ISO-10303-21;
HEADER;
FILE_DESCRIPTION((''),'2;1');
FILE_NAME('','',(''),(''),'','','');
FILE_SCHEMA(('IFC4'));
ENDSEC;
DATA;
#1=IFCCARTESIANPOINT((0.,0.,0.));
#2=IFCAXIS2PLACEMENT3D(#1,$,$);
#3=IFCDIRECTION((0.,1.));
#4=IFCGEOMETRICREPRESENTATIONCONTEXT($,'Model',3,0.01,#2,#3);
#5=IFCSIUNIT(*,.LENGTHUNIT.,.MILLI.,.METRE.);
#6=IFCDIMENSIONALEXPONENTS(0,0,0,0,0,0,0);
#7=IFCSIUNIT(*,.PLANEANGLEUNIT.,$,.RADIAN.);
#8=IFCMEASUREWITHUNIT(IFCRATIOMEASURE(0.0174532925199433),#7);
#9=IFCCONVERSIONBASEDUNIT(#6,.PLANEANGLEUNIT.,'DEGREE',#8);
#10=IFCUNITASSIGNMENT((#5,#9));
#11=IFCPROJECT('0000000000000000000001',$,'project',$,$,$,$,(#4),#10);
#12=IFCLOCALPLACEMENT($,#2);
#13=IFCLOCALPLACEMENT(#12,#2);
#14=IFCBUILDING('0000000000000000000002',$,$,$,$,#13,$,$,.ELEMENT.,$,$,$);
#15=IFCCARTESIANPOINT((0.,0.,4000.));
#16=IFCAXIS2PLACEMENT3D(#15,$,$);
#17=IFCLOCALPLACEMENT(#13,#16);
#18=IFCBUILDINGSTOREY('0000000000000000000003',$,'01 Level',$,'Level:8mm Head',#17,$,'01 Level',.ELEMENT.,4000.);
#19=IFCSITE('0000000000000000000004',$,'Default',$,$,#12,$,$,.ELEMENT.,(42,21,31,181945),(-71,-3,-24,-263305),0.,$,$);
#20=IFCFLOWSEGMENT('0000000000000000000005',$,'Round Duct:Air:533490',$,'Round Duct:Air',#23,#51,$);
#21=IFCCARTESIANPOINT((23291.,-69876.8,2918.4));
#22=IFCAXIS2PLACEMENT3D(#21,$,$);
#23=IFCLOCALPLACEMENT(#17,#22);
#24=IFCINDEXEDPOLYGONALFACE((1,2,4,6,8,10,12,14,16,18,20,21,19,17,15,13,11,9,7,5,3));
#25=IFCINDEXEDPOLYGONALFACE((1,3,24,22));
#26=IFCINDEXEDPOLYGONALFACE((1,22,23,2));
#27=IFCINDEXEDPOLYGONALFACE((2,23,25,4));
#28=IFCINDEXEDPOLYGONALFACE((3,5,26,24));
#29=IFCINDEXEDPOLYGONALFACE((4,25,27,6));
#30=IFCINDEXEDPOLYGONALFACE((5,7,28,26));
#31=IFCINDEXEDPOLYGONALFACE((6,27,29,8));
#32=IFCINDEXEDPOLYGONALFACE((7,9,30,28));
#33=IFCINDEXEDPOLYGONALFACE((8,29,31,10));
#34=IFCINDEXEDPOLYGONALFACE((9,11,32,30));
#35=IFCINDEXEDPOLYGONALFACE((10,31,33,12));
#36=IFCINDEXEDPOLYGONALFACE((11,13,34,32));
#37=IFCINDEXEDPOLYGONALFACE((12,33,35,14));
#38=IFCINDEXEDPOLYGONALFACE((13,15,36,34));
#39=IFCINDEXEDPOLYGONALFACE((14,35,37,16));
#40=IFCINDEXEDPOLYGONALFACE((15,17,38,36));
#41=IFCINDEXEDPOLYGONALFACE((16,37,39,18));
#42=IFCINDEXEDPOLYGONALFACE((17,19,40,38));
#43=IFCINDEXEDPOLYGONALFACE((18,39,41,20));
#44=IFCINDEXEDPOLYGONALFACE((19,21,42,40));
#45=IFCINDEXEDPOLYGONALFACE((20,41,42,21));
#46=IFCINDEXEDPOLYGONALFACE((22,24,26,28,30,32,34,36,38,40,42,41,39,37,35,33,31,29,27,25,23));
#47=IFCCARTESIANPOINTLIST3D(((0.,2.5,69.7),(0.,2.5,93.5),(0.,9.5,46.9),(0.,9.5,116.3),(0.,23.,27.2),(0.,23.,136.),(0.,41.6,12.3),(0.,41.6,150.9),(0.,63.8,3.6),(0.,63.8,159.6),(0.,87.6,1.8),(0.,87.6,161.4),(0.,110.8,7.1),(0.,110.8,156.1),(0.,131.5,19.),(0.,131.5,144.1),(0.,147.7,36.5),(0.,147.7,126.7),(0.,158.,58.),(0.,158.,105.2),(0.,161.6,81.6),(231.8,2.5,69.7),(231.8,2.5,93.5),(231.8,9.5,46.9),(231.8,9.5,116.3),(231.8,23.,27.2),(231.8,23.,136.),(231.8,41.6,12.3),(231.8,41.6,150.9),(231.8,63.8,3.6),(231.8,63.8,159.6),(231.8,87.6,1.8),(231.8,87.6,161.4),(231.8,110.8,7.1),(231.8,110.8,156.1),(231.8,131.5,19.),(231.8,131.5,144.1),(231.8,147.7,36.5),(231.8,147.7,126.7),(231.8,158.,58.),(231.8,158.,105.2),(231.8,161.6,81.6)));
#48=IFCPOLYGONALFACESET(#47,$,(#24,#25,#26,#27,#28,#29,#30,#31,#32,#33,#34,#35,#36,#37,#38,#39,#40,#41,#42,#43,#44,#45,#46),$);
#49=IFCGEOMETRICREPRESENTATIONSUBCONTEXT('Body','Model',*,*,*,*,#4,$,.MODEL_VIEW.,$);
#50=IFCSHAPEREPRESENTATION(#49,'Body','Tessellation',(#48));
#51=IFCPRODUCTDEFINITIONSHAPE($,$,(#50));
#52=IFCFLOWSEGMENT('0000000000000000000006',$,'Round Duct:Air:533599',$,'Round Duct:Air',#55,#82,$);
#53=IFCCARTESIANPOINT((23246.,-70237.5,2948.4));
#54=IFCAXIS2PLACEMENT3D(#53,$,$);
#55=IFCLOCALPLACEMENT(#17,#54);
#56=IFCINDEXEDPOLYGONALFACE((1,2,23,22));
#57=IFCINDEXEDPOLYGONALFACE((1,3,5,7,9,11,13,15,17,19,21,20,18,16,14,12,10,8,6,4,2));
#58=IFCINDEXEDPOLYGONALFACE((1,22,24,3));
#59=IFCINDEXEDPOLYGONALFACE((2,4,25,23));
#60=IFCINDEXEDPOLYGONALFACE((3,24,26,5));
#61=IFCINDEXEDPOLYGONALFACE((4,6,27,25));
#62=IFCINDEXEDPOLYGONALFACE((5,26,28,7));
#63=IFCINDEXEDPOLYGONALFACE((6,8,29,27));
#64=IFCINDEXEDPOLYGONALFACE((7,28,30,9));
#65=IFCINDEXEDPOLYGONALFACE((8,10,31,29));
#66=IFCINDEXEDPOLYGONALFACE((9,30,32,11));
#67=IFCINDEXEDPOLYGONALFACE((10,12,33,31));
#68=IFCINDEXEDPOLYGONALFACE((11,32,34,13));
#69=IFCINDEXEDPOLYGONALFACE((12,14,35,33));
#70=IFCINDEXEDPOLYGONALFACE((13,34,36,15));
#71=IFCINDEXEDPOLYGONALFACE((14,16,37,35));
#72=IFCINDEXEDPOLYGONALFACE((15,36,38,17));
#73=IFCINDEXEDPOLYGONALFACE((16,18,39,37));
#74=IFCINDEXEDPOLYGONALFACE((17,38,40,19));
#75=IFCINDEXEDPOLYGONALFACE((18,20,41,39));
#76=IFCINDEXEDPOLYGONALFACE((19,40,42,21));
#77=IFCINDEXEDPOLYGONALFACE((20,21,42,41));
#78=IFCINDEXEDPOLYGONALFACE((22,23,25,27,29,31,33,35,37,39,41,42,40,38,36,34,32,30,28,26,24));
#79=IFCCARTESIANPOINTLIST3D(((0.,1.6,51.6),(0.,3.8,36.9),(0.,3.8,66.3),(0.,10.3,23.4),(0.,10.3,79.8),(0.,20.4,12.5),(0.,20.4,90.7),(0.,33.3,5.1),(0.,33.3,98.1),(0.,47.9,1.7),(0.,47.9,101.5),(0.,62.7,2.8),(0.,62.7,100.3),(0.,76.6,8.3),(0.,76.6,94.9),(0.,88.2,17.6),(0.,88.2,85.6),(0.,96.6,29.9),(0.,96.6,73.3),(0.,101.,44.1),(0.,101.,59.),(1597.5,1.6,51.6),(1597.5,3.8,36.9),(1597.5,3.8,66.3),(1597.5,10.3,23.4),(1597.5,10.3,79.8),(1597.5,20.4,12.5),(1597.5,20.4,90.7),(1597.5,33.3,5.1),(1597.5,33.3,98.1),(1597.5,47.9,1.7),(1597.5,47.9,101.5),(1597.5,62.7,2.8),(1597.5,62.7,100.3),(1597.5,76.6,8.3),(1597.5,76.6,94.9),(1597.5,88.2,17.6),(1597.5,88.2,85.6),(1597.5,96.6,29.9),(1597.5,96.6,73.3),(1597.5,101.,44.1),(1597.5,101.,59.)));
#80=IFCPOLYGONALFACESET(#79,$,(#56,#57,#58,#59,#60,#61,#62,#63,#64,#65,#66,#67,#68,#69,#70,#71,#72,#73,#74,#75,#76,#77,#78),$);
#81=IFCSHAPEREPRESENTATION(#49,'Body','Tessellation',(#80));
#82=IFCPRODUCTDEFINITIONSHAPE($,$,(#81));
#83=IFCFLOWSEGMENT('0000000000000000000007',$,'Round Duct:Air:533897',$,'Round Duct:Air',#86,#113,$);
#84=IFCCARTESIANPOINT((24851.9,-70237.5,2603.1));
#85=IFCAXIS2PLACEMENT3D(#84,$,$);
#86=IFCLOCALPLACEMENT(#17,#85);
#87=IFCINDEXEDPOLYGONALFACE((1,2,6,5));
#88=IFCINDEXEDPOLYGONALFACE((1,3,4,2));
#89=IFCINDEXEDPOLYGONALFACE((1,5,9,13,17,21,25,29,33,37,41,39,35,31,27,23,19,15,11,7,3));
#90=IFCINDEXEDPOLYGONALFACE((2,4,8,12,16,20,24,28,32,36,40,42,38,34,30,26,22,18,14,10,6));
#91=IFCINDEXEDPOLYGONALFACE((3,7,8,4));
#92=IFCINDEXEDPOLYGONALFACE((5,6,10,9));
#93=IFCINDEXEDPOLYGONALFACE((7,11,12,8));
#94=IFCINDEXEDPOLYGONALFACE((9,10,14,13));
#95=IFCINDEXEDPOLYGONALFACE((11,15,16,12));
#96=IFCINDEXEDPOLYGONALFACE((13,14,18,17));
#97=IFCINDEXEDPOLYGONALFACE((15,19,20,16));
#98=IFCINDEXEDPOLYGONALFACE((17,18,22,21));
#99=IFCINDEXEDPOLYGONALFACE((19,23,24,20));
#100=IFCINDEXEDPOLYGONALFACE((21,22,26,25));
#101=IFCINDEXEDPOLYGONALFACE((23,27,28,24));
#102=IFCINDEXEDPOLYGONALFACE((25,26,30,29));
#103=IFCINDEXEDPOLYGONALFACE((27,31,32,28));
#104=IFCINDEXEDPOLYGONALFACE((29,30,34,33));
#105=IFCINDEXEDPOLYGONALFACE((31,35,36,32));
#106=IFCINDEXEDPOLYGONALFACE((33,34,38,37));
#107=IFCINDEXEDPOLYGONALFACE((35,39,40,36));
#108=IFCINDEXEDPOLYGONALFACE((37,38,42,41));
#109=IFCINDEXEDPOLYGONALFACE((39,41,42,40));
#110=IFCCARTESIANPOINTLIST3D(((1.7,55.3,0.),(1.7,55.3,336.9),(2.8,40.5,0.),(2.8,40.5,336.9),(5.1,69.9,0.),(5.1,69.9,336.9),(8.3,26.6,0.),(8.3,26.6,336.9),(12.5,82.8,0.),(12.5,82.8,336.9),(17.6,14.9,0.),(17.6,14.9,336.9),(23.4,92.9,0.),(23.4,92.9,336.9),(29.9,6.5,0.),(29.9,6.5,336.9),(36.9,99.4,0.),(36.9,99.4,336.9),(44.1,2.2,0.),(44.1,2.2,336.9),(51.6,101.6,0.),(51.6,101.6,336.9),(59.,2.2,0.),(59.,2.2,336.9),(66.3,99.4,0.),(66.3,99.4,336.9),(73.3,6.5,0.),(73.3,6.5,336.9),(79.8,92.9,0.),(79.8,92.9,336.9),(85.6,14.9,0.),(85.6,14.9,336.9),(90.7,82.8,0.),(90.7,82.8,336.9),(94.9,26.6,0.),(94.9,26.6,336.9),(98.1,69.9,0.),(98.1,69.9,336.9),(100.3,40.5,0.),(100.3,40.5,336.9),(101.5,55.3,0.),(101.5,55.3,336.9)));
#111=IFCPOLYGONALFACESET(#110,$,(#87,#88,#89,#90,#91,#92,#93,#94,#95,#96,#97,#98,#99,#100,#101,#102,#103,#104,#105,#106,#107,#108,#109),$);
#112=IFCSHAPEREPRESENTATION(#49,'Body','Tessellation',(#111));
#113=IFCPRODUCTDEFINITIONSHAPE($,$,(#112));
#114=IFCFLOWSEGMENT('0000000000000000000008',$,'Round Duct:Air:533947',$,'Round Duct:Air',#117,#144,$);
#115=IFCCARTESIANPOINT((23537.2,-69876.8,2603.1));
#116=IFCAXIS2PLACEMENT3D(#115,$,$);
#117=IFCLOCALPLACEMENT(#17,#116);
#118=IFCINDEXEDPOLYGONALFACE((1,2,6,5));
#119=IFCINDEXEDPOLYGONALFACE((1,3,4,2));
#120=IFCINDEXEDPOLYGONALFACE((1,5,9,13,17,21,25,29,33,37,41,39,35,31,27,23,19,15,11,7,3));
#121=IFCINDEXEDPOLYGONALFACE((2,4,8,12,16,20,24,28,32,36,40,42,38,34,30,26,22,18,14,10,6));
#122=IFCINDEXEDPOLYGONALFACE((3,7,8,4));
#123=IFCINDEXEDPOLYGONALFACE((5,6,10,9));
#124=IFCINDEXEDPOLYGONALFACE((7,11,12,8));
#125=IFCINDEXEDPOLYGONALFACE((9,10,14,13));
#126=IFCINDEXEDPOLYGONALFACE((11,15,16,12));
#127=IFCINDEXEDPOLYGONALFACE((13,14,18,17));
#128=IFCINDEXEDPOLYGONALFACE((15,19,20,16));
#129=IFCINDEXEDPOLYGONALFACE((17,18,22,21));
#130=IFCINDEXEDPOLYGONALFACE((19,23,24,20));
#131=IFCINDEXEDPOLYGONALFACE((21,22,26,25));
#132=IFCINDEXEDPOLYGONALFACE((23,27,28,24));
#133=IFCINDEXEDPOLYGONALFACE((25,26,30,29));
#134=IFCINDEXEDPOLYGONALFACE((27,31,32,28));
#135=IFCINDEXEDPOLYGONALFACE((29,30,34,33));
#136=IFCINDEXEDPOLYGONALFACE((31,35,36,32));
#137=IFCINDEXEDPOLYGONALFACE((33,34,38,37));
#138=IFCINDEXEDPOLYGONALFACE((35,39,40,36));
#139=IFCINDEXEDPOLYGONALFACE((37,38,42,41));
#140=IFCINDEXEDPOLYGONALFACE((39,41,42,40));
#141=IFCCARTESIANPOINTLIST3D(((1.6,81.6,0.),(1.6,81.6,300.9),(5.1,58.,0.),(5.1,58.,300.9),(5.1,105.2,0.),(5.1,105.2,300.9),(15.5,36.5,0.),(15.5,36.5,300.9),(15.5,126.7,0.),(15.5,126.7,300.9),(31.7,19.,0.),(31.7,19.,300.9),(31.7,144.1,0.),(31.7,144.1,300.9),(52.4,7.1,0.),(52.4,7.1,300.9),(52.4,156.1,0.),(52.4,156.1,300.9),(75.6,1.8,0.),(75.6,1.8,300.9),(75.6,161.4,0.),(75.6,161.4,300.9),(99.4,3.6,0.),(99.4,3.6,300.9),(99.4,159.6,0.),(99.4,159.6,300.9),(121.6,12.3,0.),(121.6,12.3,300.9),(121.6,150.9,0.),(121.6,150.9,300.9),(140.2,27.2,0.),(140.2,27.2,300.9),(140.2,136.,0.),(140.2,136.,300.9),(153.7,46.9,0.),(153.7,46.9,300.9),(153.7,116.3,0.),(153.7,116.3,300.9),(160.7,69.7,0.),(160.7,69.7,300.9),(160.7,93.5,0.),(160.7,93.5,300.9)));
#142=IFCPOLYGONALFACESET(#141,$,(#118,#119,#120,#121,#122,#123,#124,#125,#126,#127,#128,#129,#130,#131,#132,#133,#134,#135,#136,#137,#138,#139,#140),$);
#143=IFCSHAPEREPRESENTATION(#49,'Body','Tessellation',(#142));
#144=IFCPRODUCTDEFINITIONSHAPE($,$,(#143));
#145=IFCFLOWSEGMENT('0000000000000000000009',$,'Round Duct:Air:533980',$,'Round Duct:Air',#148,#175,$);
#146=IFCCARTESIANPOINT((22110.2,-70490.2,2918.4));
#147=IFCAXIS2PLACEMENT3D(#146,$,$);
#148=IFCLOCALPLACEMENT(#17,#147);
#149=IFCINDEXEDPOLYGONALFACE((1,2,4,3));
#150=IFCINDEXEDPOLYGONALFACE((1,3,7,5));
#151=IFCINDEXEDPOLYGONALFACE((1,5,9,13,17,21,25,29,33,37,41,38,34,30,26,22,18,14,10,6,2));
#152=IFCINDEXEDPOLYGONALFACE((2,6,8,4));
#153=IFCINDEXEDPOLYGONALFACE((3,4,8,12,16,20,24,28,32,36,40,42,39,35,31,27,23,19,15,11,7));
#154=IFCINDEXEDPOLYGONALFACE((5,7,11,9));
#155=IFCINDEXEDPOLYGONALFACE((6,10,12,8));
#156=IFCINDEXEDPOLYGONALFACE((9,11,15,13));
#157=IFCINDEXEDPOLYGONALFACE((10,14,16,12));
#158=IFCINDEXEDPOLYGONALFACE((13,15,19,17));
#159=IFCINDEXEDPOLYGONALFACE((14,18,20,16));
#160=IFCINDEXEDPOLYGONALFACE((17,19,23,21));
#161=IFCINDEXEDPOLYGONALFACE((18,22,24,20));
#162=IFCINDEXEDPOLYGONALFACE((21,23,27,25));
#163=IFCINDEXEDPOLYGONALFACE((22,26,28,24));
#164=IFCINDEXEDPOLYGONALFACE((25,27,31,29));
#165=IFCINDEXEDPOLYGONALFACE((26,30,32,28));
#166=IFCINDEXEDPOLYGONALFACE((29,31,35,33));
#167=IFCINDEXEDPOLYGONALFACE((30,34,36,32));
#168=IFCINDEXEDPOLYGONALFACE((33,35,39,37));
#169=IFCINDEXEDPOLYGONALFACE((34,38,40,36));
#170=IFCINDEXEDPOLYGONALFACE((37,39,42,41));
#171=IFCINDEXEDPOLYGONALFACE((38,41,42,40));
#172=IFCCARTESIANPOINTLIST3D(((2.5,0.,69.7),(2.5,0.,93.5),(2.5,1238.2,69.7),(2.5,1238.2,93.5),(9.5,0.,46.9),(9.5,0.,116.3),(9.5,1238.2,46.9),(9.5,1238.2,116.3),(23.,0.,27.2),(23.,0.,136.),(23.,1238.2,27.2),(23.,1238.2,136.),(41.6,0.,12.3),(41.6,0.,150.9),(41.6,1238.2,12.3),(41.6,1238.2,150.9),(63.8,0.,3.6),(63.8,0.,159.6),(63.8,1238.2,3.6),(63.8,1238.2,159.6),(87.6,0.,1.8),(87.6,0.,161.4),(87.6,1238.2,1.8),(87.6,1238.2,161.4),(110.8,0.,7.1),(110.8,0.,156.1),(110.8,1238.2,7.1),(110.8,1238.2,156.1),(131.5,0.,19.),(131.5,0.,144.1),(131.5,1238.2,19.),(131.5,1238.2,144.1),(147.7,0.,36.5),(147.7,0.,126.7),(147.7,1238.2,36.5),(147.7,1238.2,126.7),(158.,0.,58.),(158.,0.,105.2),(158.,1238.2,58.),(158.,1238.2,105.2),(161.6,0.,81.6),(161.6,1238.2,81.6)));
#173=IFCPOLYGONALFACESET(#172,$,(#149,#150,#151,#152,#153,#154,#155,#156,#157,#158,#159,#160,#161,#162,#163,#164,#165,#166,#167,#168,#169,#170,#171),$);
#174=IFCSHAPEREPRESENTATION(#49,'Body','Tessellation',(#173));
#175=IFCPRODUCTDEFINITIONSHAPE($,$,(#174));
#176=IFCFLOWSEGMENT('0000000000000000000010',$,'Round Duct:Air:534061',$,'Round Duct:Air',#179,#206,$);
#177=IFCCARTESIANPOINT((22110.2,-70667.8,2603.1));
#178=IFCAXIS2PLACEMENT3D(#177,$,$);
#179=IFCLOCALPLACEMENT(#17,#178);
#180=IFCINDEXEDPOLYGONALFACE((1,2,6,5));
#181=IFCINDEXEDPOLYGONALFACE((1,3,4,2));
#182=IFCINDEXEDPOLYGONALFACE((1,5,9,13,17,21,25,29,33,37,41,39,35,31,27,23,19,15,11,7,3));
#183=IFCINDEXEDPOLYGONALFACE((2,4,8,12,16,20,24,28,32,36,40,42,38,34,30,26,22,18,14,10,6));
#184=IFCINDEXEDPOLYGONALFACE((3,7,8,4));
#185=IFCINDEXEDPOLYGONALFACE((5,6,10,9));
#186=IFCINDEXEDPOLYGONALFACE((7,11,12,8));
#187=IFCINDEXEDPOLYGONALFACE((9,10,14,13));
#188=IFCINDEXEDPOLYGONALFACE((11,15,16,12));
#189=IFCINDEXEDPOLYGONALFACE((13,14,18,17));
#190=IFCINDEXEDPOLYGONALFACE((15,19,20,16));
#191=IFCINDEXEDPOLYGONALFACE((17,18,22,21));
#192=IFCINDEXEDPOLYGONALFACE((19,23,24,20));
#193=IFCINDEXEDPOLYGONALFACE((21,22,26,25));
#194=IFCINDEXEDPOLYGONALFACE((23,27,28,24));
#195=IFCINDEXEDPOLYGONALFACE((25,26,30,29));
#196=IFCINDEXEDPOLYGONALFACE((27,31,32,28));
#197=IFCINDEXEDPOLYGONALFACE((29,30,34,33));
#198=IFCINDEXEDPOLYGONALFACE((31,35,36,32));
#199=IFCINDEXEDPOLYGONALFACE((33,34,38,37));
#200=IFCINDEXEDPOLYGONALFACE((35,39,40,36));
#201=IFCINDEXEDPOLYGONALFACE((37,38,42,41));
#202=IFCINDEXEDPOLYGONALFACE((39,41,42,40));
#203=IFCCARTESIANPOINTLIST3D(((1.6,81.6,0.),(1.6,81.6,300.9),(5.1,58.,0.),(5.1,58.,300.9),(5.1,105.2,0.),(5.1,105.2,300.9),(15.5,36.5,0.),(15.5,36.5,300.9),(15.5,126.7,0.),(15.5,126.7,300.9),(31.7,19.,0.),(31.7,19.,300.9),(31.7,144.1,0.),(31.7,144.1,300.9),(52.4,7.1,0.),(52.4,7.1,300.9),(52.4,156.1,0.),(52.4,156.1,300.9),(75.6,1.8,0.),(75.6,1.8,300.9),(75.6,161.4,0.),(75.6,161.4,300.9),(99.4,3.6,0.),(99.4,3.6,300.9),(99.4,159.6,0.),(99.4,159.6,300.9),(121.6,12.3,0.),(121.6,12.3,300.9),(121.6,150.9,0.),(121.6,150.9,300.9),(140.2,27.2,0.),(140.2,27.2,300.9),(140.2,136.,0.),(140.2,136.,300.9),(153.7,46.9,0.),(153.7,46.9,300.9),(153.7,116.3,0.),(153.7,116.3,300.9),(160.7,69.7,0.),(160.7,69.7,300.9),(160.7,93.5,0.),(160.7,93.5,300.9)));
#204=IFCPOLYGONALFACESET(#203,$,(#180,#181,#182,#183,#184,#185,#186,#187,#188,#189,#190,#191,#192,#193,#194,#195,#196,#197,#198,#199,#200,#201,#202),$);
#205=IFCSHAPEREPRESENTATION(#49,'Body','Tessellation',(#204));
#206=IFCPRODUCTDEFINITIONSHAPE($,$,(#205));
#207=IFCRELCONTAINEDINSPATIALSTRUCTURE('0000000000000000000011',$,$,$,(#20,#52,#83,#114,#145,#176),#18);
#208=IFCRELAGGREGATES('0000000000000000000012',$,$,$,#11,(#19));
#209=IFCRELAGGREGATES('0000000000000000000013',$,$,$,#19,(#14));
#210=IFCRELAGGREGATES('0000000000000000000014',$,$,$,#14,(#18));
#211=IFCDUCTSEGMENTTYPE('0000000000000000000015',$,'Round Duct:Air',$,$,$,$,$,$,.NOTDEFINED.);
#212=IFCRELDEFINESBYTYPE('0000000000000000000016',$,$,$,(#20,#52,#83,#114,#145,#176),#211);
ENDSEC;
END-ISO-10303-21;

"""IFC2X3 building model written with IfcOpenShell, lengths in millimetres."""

from ifc_helpers import new_model, entity, si_unit, converted_unit, direction, frame, frame_2d, origin, origin_2d_with_axis, place, context, subcontext, project, spatial, circle, extrude, type_object, element, save


model = new_model("IFC2X3")

# Units and contexts
model_context = context("Model", 3, precision=0.01, world=origin(), true_north=direction((0.0, 1.0)))
body_context = subcontext(model_context, "Body", "Model", "MODEL_VIEW")
ifc_project = project(units=[si_unit("LENGTHUNIT", "METRE", prefix="MILLI"), converted_unit("PLANEANGLEUNIT", "DEGREE", entity("IfcRatioMeasure", 0.0174532925199433), si_unit("PLANEANGLEUNIT", "RADIAN"), dimensions=[0, 0, 0, 0, 0, 0, 0])], contexts=[model_context])

# Site, building, storey
site_placement = place(None, origin())
site = spatial("IfcSite", under=ifc_project, at=site_placement, Name="Default", CompositionType="ELEMENT", RefLatitude=(42, 21, 31, 181945), RefLongitude=(-71, -3, -24, -263305), RefElevation=0.0)
building_placement = place(site_placement, origin())
building = spatial("IfcBuilding", under=site, at=building_placement, CompositionType="ELEMENT")
storey_placement = place(building_placement, frame((0.0, 0.0, 4000.0)))
storey = spatial("IfcBuildingStorey", under=building, at=storey_placement, Name="01 Level", ObjectType="Level:8mm Head", LongName="01 Level", CompositionType="ELEMENT", Elevation=4000.0)

# Flow segments
duct_segment_type_1 = type_object("IfcDuctSegmentType", Name="Round Duct:Air", PredefinedType="NOTDEFINED")
flow_segment_1_placement = place(storey_placement, frame((23291.0, -69876.8, 2918.4)))
element("IfcFlowSegment", 1, at=flow_segment_1_placement, inside=storey, type_object=duct_segment_type_1, Name="Round Duct:Air:533490", ObjectType="Round Duct:Air", context=body_context, shape_type="SweptSolid", body=[
    extrude(circle(Radius=80.0, at=frame_2d((0.0, 0.0), x_axis=(1.0, 0.0))), frame((0.0, 81.6, 81.6), z_axis=(1.0, 0.0, 0.0), x_axis=(0.0, 1.0, 0.0)), (0.0, 0.0, 1.0), 231.8),
])
flow_segment_2_placement = place(storey_placement, frame((23246.0, -70237.5, 2948.4)))
element("IfcFlowSegment", 2, at=flow_segment_2_placement, inside=storey, type_object=duct_segment_type_1, Name="Round Duct:Air:533599", ObjectType="Round Duct:Air", context=body_context, shape_type="SweptSolid", body=[
    extrude(circle(Radius=50.0, at=origin_2d_with_axis()), frame((0.0, 51.6, 51.6), z_axis=(1.0, 0.0, 0.0), x_axis=(0.0, -1.0, 0.0)), (0.0, 0.0, 1.0), 1597.5),
])
flow_segment_3_placement = place(storey_placement, frame((24851.9, -70237.5, 2603.1)))
element("IfcFlowSegment", 3, at=flow_segment_3_placement, inside=storey, type_object=duct_segment_type_1, Name="Round Duct:Air:533897", ObjectType="Round Duct:Air", context=body_context, shape_type="SweptSolid", body=[
    extrude(circle(Radius=50.0, at=origin_2d_with_axis()), frame((51.6, 51.6, 0.0), z_axis=(0.0, 0.0, 1.0), x_axis=(0.0, 1.0, 0.0)), (0.0, 0.0, 1.0), 336.9),
])
flow_segment_4_placement = place(storey_placement, frame((23537.2, -69876.8, 2603.1)))
element("IfcFlowSegment", 4, at=flow_segment_4_placement, inside=storey, type_object=duct_segment_type_1, Name="Round Duct:Air:533947", ObjectType="Round Duct:Air", context=body_context, shape_type="SweptSolid", body=[
    extrude(circle(Radius=80.0, at=origin_2d_with_axis()), frame((81.6, 81.6, 0.0), z_axis=(0.0, 0.0, 1.0), x_axis=(-1.0, 0.0, 0.0)), (0.0, 0.0, 1.0), 300.9),
])
flow_segment_5_placement = place(storey_placement, frame((22110.2, -70490.2, 2918.4)))
element("IfcFlowSegment", 5, at=flow_segment_5_placement, inside=storey, type_object=duct_segment_type_1, Name="Round Duct:Air:533980", ObjectType="Round Duct:Air", context=body_context, shape_type="SweptSolid", body=[
    extrude(circle(Radius=80.0, at=origin_2d_with_axis()), frame((81.6, 0.0, 81.6), z_axis=(0.0, 1.0, 0.0), x_axis=(1.0, 0.0, 0.0)), (0.0, 0.0, 1.0), 1238.2),
])
flow_segment_6_placement = place(storey_placement, frame((22110.2, -70667.8, 2603.1)))
element("IfcFlowSegment", 6, at=flow_segment_6_placement, inside=storey, type_object=duct_segment_type_1, Name="Round Duct:Air:534061", ObjectType="Round Duct:Air", context=body_context, shape_type="SweptSolid", body=[
    extrude(circle(Radius=80.0, at=origin_2d_with_axis()), frame((81.6, 81.6, 0.0), z_axis=(0.0, 0.0, 1.0), x_axis=(-1.0, 0.0, 0.0)), (0.0, 0.0, 1.0), 300.9),
])

save(model, "model.ifc")
